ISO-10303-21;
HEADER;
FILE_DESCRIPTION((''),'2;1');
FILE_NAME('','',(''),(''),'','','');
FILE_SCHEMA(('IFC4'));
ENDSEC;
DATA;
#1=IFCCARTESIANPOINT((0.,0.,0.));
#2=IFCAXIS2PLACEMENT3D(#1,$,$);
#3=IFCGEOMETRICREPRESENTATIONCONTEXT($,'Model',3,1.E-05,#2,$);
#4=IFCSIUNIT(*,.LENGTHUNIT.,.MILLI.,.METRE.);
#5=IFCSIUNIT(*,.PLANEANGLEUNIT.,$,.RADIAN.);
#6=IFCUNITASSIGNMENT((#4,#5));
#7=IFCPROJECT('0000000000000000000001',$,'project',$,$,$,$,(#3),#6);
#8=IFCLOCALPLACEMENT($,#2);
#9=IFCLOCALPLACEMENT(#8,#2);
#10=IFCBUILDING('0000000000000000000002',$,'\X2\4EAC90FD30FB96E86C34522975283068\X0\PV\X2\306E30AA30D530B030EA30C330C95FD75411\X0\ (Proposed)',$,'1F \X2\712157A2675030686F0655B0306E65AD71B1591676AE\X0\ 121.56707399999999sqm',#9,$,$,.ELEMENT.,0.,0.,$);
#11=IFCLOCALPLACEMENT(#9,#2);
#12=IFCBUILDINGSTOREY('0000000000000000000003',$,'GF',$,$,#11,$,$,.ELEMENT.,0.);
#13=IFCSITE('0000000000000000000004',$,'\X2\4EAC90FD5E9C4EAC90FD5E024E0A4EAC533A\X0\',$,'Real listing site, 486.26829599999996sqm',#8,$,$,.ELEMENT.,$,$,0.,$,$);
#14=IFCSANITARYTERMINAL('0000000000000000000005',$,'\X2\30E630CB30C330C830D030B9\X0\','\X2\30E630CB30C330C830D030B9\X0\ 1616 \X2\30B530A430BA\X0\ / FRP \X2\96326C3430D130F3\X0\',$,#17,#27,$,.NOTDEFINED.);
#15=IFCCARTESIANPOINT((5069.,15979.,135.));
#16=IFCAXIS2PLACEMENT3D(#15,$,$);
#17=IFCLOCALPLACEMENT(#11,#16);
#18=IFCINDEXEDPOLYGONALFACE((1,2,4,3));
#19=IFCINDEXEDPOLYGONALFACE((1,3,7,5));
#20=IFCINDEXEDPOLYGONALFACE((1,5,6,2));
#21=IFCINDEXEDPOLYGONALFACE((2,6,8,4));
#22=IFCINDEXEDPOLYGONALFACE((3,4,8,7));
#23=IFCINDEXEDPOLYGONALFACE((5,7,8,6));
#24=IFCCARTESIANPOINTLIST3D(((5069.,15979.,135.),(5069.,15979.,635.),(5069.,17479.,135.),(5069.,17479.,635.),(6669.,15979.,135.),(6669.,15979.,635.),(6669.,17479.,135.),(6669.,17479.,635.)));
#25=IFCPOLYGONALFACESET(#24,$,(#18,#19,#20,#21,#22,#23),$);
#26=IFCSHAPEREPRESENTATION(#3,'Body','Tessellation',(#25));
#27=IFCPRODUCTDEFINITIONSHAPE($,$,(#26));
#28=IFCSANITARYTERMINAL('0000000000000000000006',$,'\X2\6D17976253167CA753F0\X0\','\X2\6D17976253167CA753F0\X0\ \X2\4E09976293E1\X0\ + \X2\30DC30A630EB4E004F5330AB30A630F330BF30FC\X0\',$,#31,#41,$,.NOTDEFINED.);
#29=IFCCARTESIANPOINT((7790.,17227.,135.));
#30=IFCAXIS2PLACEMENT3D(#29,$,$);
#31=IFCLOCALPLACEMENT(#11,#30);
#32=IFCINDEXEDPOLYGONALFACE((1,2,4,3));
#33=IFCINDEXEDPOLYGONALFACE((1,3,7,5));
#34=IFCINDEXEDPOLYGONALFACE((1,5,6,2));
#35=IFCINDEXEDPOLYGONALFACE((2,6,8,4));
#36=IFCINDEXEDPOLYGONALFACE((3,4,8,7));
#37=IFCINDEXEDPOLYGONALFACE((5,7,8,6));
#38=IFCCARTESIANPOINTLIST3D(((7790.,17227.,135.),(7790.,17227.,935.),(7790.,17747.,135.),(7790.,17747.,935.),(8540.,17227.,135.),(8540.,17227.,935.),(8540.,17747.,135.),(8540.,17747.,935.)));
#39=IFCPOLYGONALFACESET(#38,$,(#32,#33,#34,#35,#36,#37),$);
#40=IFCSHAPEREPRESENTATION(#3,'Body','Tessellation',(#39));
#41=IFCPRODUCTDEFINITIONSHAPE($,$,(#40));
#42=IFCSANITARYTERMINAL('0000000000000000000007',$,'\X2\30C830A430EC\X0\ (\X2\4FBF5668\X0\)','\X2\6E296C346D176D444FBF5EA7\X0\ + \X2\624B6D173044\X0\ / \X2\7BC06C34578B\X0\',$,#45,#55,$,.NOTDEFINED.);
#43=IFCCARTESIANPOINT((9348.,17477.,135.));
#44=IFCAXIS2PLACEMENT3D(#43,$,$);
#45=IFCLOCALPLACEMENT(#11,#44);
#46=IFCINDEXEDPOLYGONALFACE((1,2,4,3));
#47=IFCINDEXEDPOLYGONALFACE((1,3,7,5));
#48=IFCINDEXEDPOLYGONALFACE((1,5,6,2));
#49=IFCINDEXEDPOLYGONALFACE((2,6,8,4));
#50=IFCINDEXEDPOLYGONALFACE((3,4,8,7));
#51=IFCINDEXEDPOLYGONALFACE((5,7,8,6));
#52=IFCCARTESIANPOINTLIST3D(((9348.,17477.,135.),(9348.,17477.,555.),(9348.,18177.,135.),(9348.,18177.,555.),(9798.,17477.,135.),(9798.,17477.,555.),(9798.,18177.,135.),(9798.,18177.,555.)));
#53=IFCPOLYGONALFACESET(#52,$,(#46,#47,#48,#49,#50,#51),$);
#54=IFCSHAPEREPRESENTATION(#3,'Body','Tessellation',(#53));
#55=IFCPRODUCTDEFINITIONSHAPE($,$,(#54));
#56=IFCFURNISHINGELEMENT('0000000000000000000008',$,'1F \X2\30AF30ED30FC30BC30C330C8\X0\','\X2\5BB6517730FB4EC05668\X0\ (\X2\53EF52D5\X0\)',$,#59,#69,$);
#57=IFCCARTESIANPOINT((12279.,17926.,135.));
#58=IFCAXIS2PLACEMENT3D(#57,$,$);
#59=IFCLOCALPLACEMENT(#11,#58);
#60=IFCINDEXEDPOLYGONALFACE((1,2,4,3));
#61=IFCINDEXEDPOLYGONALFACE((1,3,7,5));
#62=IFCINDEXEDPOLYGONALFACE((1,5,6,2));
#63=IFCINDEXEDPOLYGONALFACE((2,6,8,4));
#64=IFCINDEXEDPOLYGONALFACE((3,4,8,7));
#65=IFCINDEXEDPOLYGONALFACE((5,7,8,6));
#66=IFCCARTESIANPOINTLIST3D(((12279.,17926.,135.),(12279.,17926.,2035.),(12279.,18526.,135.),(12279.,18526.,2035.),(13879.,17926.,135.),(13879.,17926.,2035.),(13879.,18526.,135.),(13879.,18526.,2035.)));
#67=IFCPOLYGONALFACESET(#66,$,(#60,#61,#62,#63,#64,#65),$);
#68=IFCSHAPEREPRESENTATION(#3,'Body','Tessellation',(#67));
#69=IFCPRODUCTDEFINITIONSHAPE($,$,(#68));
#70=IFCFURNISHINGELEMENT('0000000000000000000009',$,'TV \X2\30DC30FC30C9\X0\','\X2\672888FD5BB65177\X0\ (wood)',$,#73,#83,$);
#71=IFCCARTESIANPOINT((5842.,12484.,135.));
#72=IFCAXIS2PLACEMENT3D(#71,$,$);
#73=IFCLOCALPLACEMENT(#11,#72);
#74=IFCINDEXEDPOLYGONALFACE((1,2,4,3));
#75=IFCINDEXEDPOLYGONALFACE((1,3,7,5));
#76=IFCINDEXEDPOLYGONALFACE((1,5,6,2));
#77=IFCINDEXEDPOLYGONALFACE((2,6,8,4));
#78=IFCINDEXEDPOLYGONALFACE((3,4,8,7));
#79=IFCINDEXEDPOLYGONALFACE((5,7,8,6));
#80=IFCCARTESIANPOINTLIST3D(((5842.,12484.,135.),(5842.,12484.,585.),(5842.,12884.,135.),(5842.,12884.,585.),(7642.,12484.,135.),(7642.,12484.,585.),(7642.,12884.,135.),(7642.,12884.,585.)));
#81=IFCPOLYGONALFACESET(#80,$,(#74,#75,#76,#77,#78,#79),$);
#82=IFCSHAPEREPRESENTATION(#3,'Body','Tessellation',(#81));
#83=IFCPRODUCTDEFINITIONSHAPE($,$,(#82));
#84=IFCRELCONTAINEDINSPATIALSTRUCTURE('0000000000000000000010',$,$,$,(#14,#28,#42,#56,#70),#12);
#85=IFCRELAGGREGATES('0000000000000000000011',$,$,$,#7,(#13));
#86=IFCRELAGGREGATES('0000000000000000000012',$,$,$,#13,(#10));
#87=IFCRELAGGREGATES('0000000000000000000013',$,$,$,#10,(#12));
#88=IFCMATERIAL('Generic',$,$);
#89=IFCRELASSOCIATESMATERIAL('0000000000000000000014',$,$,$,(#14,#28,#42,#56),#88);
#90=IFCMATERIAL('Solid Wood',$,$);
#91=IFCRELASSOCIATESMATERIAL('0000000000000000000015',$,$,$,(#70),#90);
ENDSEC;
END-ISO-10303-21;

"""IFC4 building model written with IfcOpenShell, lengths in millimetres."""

from ifc_helpers import new_model, si_unit, frame, frame_2d, origin, place, context, project, spatial, rectangle, extrude, material, element, save


model = new_model("IFC4")

# Units and contexts
model_context = context("Model", 3, precision=1e-05, world=origin())
ifc_project = project(units=[si_unit("LENGTHUNIT", "METRE", prefix="MILLI"), si_unit("PLANEANGLEUNIT", "RADIAN")], contexts=[model_context])

# Site, building, storey
site_placement = place(None, origin())
site = spatial("IfcSite", under=ifc_project, at=site_placement, Name="京都府京都市上京区", ObjectType="Real listing site, 486.26829599999996sqm", CompositionType="ELEMENT", RefElevation=0.0)
building_placement = place(site_placement, origin())
building = spatial("IfcBuilding", under=site, at=building_placement, Name="京都・雨水利用とPVのオフグリッド志向 (Proposed)", ObjectType="1F 無垢材と漆喰の断熱外皮 121.56707399999999sqm", CompositionType="ELEMENT", ElevationOfRefHeight=0.0, ElevationOfTerrain=0.0)
storey_placement = place(building_placement, origin())
storey = spatial("IfcBuildingStorey", under=building, at=storey_placement, Name="GF", CompositionType="ELEMENT", Elevation=0.0)

# Shared definitions
ifc_material_1 = material(Name="Solid Wood")

# Sanitary terminals
ifc_material_2 = material(Name="Generic")
sanitary_terminal_1_placement = place(storey_placement, frame((5069.0, 15979.0, 135.0)))
element("IfcSanitaryTerminal", 1, at=sanitary_terminal_1_placement, inside=storey, material=ifc_material_2, Name="ユニットバス", Description="ユニットバス 1616 サイズ / FRP 防水パン", PredefinedType="NOTDEFINED", context=model_context, shape_type="SweptSolid", body=[
    extrude(rectangle(XDim=1600.0, YDim=1500.0, at=frame_2d((800.0, 750.0))), frame((5069.0, 15979.0, 135.0)), (0.0, 0.0, 1.0), 500.0),
])
sanitary_terminal_2_placement = place(storey_placement, frame((7790.0, 17227.0, 135.0)))
element("IfcSanitaryTerminal", 2, at=sanitary_terminal_2_placement, inside=storey, material=ifc_material_2, Name="洗面化粧台", Description="洗面化粧台 三面鏡 + ボウル一体カウンター", PredefinedType="NOTDEFINED", context=model_context, shape_type="SweptSolid", body=[
    extrude(rectangle(XDim=750.0, YDim=520.0, at=frame_2d((375.0, 260.0))), frame((7790.0, 17227.0, 135.0)), (0.0, 0.0, 1.0), 800.0),
])
sanitary_terminal_3_placement = place(storey_placement, frame((9348.0, 17477.0, 135.0)))
element("IfcSanitaryTerminal", 3, at=sanitary_terminal_3_placement, inside=storey, material=ifc_material_2, Name="トイレ (便器)", Description="温水洗浄便座 + 手洗い / 節水型", PredefinedType="NOTDEFINED", context=model_context, shape_type="SweptSolid", body=[
    extrude(rectangle(XDim=450.0, YDim=700.0, at=frame_2d((225.0, 350.0))), frame((9348.0, 17477.0, 135.0)), (0.0, 0.0, 1.0), 420.0),
])

# Furnishing elements
furnishing_1_placement = place(storey_placement, frame((12279.0, 17926.0, 135.0)))
element("IfcFurnishingElement", 4, at=furnishing_1_placement, inside=storey, material=ifc_material_2, Name="1F クローゼット", Description="家具・什器 (可動)", context=model_context, shape_type="SweptSolid", body=[
    extrude(rectangle(XDim=1600.0, YDim=600.0, at=frame_2d((800.0, 300.0))), frame((12279.0, 17926.0, 135.0)), (0.0, 0.0, 1.0), 1900.0),
])
furnishing_2_placement = place(storey_placement, frame((5842.0, 12484.0, 135.0)))
element("IfcFurnishingElement", 5, at=furnishing_2_placement, inside=storey, material=ifc_material_1, Name="TV ボード", Description="木製家具 (wood)", context=model_context, shape_type="SweptSolid", body=[
    extrude(rectangle(XDim=1800.0, YDim=400.0, at=frame_2d((900.0, 200.0))), frame((5842.0, 12484.0, 135.0)), (0.0, 0.0, 1.0), 450.0),
])

save(model, "model.ifc")
